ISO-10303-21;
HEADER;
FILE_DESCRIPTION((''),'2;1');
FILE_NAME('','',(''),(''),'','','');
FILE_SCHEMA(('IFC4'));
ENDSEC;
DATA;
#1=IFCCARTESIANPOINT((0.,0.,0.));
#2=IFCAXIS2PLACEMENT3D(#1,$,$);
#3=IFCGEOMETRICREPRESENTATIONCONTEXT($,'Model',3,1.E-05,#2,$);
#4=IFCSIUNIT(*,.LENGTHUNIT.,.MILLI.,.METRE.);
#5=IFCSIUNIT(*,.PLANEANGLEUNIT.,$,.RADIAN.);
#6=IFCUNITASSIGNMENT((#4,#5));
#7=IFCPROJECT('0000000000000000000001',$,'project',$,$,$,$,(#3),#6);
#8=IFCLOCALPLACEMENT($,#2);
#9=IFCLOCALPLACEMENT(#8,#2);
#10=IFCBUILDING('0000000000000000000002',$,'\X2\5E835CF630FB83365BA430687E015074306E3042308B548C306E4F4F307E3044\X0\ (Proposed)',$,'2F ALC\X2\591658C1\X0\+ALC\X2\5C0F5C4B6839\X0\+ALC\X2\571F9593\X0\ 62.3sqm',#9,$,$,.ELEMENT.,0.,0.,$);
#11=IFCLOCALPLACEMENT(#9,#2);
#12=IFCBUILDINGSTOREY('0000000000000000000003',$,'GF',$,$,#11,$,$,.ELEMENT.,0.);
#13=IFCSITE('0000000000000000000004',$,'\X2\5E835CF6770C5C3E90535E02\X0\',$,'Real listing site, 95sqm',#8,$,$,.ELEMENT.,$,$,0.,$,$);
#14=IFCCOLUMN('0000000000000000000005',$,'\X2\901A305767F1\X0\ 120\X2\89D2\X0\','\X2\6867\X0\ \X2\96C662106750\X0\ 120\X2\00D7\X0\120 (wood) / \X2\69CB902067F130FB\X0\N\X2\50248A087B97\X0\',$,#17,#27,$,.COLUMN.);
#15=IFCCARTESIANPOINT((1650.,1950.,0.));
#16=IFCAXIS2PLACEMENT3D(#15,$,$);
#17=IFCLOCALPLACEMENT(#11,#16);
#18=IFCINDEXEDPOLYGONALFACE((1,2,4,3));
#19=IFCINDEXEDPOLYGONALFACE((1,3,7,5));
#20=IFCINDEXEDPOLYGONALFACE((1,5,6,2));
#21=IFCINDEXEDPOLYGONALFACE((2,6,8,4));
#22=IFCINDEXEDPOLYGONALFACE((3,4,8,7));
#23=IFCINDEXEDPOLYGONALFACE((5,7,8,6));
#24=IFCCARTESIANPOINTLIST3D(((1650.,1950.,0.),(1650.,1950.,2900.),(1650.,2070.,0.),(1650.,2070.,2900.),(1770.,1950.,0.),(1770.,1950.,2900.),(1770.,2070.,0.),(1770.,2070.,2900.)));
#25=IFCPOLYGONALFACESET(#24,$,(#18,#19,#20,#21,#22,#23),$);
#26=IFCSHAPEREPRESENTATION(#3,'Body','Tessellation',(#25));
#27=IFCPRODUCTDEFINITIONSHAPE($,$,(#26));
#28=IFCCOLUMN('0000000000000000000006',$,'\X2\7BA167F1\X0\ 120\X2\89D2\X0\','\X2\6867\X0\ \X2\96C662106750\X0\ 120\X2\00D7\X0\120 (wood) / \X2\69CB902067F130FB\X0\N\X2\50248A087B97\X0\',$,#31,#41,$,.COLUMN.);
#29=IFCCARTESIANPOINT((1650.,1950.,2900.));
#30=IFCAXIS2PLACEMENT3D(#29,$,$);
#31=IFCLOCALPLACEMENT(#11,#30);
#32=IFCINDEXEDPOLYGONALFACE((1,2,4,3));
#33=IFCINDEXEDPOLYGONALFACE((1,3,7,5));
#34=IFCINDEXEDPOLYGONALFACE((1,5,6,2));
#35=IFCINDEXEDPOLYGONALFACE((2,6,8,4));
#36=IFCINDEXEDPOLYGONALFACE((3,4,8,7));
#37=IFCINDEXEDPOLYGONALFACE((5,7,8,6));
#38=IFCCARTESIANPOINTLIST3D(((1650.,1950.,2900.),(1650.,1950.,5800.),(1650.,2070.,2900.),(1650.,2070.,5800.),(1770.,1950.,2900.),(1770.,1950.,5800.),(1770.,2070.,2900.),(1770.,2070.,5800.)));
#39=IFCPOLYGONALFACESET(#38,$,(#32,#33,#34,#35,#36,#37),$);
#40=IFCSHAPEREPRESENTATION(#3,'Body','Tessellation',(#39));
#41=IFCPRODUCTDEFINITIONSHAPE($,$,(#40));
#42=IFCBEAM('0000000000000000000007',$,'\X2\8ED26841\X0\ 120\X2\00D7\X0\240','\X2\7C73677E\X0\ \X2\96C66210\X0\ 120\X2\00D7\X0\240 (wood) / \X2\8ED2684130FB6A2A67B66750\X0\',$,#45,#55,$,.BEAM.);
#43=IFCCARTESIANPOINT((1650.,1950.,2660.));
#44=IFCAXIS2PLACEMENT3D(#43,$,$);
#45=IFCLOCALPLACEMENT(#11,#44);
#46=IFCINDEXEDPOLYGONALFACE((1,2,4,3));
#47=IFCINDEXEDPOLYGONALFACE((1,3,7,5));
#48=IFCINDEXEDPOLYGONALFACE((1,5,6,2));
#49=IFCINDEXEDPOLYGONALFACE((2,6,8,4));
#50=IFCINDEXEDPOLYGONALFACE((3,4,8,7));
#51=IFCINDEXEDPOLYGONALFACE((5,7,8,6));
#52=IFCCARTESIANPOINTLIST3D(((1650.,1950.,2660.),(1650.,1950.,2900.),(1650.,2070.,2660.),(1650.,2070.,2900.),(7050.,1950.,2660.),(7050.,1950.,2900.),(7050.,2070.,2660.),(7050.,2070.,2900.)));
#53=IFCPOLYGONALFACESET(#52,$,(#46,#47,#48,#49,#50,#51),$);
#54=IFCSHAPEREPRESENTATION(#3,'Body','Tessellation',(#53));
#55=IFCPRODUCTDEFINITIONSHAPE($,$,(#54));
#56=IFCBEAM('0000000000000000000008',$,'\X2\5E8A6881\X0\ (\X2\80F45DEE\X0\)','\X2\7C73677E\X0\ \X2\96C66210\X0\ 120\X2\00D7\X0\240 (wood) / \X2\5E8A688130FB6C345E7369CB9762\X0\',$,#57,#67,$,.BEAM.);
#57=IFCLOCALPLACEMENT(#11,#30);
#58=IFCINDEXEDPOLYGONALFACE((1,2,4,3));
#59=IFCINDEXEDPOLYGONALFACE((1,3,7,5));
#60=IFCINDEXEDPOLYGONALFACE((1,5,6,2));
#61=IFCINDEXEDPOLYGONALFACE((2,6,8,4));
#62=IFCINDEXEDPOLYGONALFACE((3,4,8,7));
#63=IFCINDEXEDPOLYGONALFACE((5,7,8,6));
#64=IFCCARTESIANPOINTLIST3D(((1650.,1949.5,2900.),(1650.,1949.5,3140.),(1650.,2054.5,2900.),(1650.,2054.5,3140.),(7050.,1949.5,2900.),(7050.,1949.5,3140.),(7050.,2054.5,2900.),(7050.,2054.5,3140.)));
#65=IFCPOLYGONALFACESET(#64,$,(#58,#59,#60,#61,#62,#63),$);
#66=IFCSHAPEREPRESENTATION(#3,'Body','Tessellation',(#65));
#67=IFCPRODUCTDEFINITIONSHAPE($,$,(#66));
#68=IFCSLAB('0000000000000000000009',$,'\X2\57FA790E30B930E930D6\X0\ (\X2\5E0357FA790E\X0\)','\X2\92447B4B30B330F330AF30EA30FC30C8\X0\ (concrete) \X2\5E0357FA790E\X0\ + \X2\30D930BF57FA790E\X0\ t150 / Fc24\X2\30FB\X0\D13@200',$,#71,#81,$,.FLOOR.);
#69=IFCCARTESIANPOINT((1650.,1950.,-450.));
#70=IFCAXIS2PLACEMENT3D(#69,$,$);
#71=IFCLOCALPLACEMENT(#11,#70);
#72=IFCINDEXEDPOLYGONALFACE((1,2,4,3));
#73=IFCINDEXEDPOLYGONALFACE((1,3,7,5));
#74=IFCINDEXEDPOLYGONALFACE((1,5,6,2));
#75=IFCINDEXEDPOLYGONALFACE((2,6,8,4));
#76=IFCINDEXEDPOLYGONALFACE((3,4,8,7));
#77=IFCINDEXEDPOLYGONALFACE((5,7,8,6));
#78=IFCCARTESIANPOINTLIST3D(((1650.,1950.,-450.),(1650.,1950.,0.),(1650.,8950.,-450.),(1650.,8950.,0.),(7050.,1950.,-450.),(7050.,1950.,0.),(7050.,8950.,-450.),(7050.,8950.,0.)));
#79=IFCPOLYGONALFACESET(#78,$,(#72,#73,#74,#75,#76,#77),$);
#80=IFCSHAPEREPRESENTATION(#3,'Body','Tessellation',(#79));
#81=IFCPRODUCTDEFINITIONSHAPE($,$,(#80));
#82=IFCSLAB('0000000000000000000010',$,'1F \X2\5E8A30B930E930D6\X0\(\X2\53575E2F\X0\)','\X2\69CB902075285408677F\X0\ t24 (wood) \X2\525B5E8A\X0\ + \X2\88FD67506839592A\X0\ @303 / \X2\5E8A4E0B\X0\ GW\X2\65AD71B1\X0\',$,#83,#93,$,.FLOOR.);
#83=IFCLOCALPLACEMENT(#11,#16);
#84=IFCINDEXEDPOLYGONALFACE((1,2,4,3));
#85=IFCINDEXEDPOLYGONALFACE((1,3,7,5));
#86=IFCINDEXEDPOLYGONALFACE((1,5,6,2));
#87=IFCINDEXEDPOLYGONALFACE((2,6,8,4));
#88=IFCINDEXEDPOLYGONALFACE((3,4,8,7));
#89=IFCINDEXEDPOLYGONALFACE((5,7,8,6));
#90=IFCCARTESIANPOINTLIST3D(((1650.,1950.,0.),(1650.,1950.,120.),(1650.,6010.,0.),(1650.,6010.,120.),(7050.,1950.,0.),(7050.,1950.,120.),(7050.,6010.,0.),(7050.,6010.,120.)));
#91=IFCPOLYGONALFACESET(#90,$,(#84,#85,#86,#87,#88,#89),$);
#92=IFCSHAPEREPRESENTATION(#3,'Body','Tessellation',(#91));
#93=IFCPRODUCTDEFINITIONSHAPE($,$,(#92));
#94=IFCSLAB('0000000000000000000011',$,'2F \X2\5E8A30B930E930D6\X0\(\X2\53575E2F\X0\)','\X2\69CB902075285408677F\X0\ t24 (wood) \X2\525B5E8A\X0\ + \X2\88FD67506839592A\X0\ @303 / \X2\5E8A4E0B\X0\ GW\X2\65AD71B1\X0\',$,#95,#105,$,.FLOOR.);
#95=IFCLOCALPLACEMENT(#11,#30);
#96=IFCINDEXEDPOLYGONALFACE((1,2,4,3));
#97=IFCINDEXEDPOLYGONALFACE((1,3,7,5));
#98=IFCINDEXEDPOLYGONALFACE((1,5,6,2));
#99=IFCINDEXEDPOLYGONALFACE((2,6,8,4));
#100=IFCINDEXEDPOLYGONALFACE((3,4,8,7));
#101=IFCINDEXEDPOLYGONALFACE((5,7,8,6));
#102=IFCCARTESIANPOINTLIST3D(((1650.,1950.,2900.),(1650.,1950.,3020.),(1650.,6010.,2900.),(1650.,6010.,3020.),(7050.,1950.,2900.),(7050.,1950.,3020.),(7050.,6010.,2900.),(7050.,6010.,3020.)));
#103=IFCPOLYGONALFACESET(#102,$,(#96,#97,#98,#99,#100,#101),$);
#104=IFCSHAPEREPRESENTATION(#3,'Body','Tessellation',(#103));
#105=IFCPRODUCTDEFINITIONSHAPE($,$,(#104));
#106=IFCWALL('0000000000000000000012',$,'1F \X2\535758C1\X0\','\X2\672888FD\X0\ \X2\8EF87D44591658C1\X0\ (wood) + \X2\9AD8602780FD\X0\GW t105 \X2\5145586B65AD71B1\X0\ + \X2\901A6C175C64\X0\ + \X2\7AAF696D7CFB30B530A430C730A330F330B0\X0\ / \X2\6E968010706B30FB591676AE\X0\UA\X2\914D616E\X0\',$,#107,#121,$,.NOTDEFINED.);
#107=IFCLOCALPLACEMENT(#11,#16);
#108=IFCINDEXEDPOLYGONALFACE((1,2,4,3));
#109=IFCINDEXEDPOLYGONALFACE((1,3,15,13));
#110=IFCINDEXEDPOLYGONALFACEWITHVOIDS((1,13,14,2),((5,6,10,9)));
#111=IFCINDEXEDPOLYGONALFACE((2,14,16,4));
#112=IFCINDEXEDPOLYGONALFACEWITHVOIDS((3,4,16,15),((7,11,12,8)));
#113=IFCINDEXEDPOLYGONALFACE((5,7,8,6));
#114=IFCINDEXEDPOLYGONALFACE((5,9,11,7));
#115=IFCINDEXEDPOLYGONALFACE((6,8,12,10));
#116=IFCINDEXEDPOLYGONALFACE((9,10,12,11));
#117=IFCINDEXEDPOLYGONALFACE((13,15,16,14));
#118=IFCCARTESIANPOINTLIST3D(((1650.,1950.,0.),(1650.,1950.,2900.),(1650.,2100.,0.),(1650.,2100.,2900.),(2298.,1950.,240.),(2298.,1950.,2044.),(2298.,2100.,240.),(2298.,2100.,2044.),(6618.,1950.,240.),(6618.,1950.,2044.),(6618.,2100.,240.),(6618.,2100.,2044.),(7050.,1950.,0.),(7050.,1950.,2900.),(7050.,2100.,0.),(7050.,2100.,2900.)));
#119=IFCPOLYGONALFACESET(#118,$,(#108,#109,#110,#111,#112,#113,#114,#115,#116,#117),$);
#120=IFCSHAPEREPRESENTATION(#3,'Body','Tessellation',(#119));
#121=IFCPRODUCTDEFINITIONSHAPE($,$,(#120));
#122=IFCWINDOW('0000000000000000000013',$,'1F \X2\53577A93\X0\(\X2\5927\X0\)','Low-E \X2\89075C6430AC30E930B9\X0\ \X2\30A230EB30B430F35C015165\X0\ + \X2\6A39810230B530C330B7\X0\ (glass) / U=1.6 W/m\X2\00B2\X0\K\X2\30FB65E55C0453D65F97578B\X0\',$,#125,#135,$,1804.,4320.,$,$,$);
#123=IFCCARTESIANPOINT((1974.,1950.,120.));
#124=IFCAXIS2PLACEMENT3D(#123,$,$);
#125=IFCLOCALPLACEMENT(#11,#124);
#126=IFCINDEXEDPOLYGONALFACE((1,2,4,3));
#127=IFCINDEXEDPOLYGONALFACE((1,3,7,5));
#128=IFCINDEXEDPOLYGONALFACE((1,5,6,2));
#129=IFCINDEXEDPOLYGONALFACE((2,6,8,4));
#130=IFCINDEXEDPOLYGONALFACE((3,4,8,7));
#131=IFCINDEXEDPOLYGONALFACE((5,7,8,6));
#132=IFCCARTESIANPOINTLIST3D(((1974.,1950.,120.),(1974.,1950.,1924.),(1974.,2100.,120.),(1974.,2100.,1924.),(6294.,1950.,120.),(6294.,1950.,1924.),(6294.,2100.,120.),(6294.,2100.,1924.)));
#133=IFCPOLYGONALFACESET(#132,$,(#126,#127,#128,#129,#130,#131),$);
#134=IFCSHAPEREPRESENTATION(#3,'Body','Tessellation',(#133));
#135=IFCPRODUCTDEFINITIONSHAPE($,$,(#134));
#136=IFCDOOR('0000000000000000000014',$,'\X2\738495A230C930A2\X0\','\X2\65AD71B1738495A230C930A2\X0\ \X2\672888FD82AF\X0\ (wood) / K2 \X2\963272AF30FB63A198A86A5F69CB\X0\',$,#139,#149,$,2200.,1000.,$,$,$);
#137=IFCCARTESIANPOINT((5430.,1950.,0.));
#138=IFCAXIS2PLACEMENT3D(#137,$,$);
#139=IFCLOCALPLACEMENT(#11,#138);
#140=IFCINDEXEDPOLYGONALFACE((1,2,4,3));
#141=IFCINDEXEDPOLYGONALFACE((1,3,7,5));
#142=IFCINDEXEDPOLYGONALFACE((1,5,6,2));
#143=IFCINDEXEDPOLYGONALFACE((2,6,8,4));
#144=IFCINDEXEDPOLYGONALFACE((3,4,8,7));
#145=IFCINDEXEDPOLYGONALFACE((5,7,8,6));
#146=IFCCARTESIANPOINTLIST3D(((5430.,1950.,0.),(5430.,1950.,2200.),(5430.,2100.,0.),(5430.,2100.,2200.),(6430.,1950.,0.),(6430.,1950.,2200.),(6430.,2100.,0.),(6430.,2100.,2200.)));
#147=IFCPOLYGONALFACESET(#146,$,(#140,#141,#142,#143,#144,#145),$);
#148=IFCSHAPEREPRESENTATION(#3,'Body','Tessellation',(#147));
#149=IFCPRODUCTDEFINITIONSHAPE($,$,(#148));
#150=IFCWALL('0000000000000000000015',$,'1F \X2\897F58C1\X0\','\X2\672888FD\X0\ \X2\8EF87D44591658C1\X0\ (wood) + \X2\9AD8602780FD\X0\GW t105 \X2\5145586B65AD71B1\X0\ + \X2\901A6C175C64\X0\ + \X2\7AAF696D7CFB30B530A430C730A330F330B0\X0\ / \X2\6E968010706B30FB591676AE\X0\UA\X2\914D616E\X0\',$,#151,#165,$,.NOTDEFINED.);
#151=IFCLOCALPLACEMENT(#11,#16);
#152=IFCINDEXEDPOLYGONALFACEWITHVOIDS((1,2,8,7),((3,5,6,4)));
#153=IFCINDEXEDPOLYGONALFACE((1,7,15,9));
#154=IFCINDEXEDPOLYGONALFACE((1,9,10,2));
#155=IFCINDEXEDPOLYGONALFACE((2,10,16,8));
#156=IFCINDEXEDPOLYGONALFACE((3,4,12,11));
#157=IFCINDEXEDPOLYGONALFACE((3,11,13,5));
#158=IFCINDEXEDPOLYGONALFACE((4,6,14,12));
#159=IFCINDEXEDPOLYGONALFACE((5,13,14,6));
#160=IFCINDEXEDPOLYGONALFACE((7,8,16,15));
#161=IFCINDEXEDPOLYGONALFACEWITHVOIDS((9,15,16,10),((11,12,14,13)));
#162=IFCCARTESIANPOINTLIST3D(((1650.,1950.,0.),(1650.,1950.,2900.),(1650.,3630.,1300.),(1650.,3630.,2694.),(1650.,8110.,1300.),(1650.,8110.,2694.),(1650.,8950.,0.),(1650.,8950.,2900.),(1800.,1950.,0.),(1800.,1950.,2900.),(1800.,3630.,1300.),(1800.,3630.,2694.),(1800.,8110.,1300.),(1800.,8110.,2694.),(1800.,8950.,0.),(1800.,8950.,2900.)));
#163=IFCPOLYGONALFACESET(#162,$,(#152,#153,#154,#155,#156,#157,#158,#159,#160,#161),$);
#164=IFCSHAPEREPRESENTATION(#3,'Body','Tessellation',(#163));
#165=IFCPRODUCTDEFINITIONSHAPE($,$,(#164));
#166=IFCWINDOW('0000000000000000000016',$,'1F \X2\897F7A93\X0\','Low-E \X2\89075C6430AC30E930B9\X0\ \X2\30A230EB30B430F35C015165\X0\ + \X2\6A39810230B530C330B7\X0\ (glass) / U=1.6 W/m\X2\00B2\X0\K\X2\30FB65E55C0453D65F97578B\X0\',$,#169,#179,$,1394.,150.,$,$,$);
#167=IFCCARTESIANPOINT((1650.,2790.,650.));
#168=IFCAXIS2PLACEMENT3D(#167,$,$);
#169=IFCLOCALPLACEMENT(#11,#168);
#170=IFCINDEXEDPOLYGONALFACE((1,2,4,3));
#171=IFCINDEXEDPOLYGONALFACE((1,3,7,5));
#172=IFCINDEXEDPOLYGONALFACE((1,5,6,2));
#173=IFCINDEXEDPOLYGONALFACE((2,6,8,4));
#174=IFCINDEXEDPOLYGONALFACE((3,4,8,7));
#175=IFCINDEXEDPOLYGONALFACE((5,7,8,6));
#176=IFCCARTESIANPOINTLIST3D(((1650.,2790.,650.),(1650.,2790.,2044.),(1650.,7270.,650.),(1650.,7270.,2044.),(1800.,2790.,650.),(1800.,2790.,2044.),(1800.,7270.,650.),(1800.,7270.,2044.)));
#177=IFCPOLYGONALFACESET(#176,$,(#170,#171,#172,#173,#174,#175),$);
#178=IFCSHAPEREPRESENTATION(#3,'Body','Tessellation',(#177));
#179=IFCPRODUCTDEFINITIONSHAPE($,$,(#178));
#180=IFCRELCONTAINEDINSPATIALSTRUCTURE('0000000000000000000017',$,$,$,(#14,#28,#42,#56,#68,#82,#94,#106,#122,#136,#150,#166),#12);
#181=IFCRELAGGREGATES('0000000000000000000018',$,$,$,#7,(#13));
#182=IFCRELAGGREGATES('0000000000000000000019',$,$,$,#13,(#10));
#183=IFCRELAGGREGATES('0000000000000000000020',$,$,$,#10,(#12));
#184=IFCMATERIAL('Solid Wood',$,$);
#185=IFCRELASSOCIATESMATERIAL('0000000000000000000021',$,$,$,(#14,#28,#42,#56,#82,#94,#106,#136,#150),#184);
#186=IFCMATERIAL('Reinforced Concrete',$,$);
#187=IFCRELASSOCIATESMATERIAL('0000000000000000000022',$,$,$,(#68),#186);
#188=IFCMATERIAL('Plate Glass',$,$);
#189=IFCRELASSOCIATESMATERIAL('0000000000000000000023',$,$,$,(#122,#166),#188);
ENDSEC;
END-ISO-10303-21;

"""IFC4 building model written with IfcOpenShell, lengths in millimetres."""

from ifc_helpers import new_model, si_unit, frame, frame_2d, origin, place, context, project, spatial, rectangle, extrude, material, element, fill, save


model = new_model("IFC4")

# Units and contexts
model_context = context("Model", 3, precision=1e-05, world=origin())
ifc_project = project(units=[si_unit("LENGTHUNIT", "METRE", prefix="MILLI"), si_unit("PLANEANGLEUNIT", "RADIAN")], contexts=[model_context])

# Site, building, storey
site_placement = place(None, origin())
site = spatial("IfcSite", under=ifc_project, at=site_placement, Name="広島県尾道市", ObjectType="Real listing site, 95sqm", CompositionType="ELEMENT", RefElevation=0.0)
building_placement = place(site_placement, origin())
building = spatial("IfcBuilding", under=site, at=building_placement, Name="広島・茶室と縁側のある和の住まい (Proposed)", ObjectType="2F ALC外壁+ALC小屋根+ALC土間 62.3sqm", CompositionType="ELEMENT", ElevationOfRefHeight=0.0, ElevationOfTerrain=0.0)
storey_placement = place(building_placement, origin())
storey = spatial("IfcBuildingStorey", under=building, at=storey_placement, Name="GF", CompositionType="ELEMENT", Elevation=0.0)

# Columns
ifc_material_1 = material(Name="Solid Wood")
column_1_placement = place(storey_placement, frame((1650.0, 1950.0, 0.0)))
element("IfcColumn", 1, at=column_1_placement, inside=storey, material=ifc_material_1, Name="通し柱 120角", Description="桧 集成材 120×120 (wood) / 構造柱・N値計算", PredefinedType="COLUMN", context=model_context, shape_type="SweptSolid", body=[
    extrude(rectangle(XDim=120.0, YDim=120.0, at=frame_2d((60.0, 60.0))), frame((1650.0, 1950.0, 0.0)), (0.0, 0.0, 1.0), 2900.0),
])
column_2_placement = place(storey_placement, frame((1650.0, 1950.0, 2900.0)))
element("IfcColumn", 2, at=column_2_placement, inside=storey, material=ifc_material_1, Name="管柱 120角", Description="桧 集成材 120×120 (wood) / 構造柱・N値計算", PredefinedType="COLUMN", context=model_context, shape_type="SweptSolid", body=[
    extrude(rectangle(XDim=120.0, YDim=120.0, at=frame_2d((60.0, 60.0))), frame((1650.0, 1950.0, 2900.0)), (0.0, 0.0, 1.0), 2900.0),
])

# Beams
beam_1_placement = place(storey_placement, frame((1650.0, 1950.0, 2660.0)))
element("IfcBeam", 3, at=beam_1_placement, inside=storey, material=ifc_material_1, Name="軒桁 120×240", Description="米松 集成 120×240 (wood) / 軒桁・横架材", PredefinedType="BEAM", context=model_context, shape_type="SweptSolid", body=[
    extrude(rectangle(XDim=5400.0, YDim=120.0, at=frame_2d((2700.0, 60.0))), frame((1650.0, 1950.0, 2660.0)), (0.0, 0.0, 1.0), 240.0),
])
beam_2_placement = place(storey_placement, frame((1650.0, 1950.0, 2900.0)))
element("IfcBeam", 4, at=beam_2_placement, inside=storey, material=ifc_material_1, Name="床梁 (胴差)", Description="米松 集成 120×240 (wood) / 床梁・水平構面", PredefinedType="BEAM", context=model_context, shape_type="SweptSolid", body=[
    extrude(rectangle(XDim=5400.0, YDim=105.0, at=frame_2d((2700.0, 52.0))), frame((1650.0, 1950.0, 2900.0)), (0.0, 0.0, 1.0), 240.0),
])

# Slabs
ifc_material_2 = material(Name="Reinforced Concrete")
slab_1_placement = place(storey_placement, frame((1650.0, 1950.0, -450.0)))
element("IfcSlab", 5, at=slab_1_placement, inside=storey, material=ifc_material_2, Name="基礎スラブ (布基礎)", Description="鉄筋コンクリート (concrete) 布基礎 + ベタ基礎 t150 / Fc24・D13@200", PredefinedType="FLOOR", context=model_context, shape_type="SweptSolid", body=[
    extrude(rectangle(XDim=5400.0, YDim=7000.0, at=frame_2d((2700.0, 3500.0))), frame((1650.0, 1950.0, -450.0)), (0.0, 0.0, 1.0), 450.0),
])
slab_2_placement = place(storey_placement, frame((1650.0, 1950.0, 0.0)))
element("IfcSlab", 6, at=slab_2_placement, inside=storey, material=ifc_material_1, Name="1F 床スラブ(南帯)", Description="構造用合板 t24 (wood) 剛床 + 製材根太 @303 / 床下 GW断熱", PredefinedType="FLOOR", context=model_context, shape_type="SweptSolid", body=[
    extrude(rectangle(XDim=5400.0, YDim=4060.0, at=frame_2d((2700.0, 2030.0))), frame((1650.0, 1950.0, 0.0)), (0.0, 0.0, 1.0), 120.0),
])
slab_3_placement = place(storey_placement, frame((1650.0, 1950.0, 2900.0)))
element("IfcSlab", 7, at=slab_3_placement, inside=storey, material=ifc_material_1, Name="2F 床スラブ(南帯)", Description="構造用合板 t24 (wood) 剛床 + 製材根太 @303 / 床下 GW断熱", PredefinedType="FLOOR", context=model_context, shape_type="SweptSolid", body=[
    extrude(rectangle(XDim=5400.0, YDim=4060.0, at=frame_2d((2700.0, 2030.0))), frame((1650.0, 1950.0, 2900.0)), (0.0, 0.0, 1.0), 120.0),
])

# Wall, openings, window, door
wall_1_placement = place(storey_placement, frame((1650.0, 1950.0, 0.0)))
wall_1 = element("IfcWall", 8, at=wall_1_placement, inside=storey, material=ifc_material_1, Name="1F 南壁", Description="木製 軸組外壁 (wood) + 高性能GW t105 充填断熱 + 通気層 + 窯業系サイディング / 準耐火・外皮UA配慮", PredefinedType="NOTDEFINED", context=model_context, shape_type="SweptSolid", body=[
    extrude(rectangle(XDim=5400.0, YDim=150.0, at=frame_2d((2700.0, 75.0))), frame((1650.0, 1950.0, 0.0)), (0.0, 0.0, 1.0), 2900.0),
])
opening_1_placement = place(storey_placement, frame((1974.0, 1950.0, 120.0)))
opening_1 = element("IfcOpeningElement", 9, at=opening_1_placement, cuts=wall_1, PredefinedType="NOTDEFINED", context=model_context, shape_type="SweptSolid", body=[
    extrude(rectangle(XDim=4320.0, YDim=150.0, at=frame_2d((2160.0, 75.0))), frame((1974.0, 1950.0, 120.0)), (0.0, 0.0, 1.0), 1804.0),
])
opening_2_placement = place(storey_placement, frame((5430.0, 1950.0, 0.0)))
opening_2 = element("IfcOpeningElement", 10, at=opening_2_placement, cuts=wall_1, PredefinedType="NOTDEFINED", context=model_context, shape_type="SweptSolid", body=[
    extrude(rectangle(XDim=1000.0, YDim=150.0, at=frame_2d((500.0, 75.0))), frame((5430.0, 1950.0, 0.0)), (0.0, 0.0, 1.0), 2200.0),
])
ifc_material_3 = material(Name="Plate Glass")
window_1_placement = place(storey_placement, frame((1974.0, 1950.0, 120.0)))
window_1 = element("IfcWindow", 11, at=window_1_placement, inside=storey, material=ifc_material_3, Name="1F 南窓(大)", Description="Low-E 複層ガラス アルゴン封入 + 樹脂サッシ (glass) / U=1.6 W/m²K・日射取得型", OverallHeight=1804.0, OverallWidth=4320.0, context=model_context, shape_type="SweptSolid", body=[
    extrude(rectangle(XDim=4320.0, YDim=150.0, at=frame_2d((2160.0, 75.0))), frame((1974.0, 1950.0, 120.0)), (0.0, 0.0, 1.0), 1804.0),
])
fill(opening_1, window_1)
door_placement = place(storey_placement, frame((5430.0, 1950.0, 0.0)))
door = element("IfcDoor", 12, at=door_placement, inside=storey, material=ifc_material_1, Name="玄関ドア", Description="断熱玄関ドア 木製芯 (wood) / K2 防犯・採風機構", OverallHeight=2200.0, OverallWidth=1000.0, context=model_context, shape_type="SweptSolid", body=[
    extrude(rectangle(XDim=1000.0, YDim=150.0, at=frame_2d((500.0, 75.0))), frame((5430.0, 1950.0, 0.0)), (0.0, 0.0, 1.0), 2200.0),
])
fill(opening_2, door)

# Wall, opening, window
wall_2_placement = place(storey_placement, frame((1650.0, 1950.0, 0.0)))
wall_2 = element("IfcWall", 13, at=wall_2_placement, inside=storey, material=ifc_material_1, Name="1F 西壁", Description="木製 軸組外壁 (wood) + 高性能GW t105 充填断熱 + 通気層 + 窯業系サイディング / 準耐火・外皮UA配慮", PredefinedType="NOTDEFINED", context=model_context, shape_type="SweptSolid", body=[
    extrude(rectangle(XDim=150.0, YDim=7000.0, at=frame_2d((75.0, 3500.0))), frame((1650.0, 1950.0, 0.0)), (0.0, 0.0, 1.0), 2900.0),
])
opening_3_placement = place(storey_placement, frame((1650.0, 2790.0, 650.0)))
opening_3 = element("IfcOpeningElement", 14, at=opening_3_placement, cuts=wall_2, PredefinedType="NOTDEFINED", context=model_context, shape_type="SweptSolid", body=[
    extrude(rectangle(XDim=150.0, YDim=4480.0, at=frame_2d((75.0, 2240.0))), frame((1650.0, 2790.0, 650.0)), (0.0, 0.0, 1.0), 1394.0),
])
window_2_placement = place(storey_placement, frame((1650.0, 2790.0, 650.0)))
window_2 = element("IfcWindow", 15, at=window_2_placement, inside=storey, material=ifc_material_3, Name="1F 西窓", Description="Low-E 複層ガラス アルゴン封入 + 樹脂サッシ (glass) / U=1.6 W/m²K・日射取得型", OverallHeight=1394.0, OverallWidth=150.0, context=model_context, shape_type="SweptSolid", body=[
    extrude(rectangle(XDim=150.0, YDim=4480.0, at=frame_2d((75.0, 2240.0))), frame((1650.0, 2790.0, 650.0)), (0.0, 0.0, 1.0), 1394.0),
])
fill(opening_3, window_2)

save(model, "model.ifc")
